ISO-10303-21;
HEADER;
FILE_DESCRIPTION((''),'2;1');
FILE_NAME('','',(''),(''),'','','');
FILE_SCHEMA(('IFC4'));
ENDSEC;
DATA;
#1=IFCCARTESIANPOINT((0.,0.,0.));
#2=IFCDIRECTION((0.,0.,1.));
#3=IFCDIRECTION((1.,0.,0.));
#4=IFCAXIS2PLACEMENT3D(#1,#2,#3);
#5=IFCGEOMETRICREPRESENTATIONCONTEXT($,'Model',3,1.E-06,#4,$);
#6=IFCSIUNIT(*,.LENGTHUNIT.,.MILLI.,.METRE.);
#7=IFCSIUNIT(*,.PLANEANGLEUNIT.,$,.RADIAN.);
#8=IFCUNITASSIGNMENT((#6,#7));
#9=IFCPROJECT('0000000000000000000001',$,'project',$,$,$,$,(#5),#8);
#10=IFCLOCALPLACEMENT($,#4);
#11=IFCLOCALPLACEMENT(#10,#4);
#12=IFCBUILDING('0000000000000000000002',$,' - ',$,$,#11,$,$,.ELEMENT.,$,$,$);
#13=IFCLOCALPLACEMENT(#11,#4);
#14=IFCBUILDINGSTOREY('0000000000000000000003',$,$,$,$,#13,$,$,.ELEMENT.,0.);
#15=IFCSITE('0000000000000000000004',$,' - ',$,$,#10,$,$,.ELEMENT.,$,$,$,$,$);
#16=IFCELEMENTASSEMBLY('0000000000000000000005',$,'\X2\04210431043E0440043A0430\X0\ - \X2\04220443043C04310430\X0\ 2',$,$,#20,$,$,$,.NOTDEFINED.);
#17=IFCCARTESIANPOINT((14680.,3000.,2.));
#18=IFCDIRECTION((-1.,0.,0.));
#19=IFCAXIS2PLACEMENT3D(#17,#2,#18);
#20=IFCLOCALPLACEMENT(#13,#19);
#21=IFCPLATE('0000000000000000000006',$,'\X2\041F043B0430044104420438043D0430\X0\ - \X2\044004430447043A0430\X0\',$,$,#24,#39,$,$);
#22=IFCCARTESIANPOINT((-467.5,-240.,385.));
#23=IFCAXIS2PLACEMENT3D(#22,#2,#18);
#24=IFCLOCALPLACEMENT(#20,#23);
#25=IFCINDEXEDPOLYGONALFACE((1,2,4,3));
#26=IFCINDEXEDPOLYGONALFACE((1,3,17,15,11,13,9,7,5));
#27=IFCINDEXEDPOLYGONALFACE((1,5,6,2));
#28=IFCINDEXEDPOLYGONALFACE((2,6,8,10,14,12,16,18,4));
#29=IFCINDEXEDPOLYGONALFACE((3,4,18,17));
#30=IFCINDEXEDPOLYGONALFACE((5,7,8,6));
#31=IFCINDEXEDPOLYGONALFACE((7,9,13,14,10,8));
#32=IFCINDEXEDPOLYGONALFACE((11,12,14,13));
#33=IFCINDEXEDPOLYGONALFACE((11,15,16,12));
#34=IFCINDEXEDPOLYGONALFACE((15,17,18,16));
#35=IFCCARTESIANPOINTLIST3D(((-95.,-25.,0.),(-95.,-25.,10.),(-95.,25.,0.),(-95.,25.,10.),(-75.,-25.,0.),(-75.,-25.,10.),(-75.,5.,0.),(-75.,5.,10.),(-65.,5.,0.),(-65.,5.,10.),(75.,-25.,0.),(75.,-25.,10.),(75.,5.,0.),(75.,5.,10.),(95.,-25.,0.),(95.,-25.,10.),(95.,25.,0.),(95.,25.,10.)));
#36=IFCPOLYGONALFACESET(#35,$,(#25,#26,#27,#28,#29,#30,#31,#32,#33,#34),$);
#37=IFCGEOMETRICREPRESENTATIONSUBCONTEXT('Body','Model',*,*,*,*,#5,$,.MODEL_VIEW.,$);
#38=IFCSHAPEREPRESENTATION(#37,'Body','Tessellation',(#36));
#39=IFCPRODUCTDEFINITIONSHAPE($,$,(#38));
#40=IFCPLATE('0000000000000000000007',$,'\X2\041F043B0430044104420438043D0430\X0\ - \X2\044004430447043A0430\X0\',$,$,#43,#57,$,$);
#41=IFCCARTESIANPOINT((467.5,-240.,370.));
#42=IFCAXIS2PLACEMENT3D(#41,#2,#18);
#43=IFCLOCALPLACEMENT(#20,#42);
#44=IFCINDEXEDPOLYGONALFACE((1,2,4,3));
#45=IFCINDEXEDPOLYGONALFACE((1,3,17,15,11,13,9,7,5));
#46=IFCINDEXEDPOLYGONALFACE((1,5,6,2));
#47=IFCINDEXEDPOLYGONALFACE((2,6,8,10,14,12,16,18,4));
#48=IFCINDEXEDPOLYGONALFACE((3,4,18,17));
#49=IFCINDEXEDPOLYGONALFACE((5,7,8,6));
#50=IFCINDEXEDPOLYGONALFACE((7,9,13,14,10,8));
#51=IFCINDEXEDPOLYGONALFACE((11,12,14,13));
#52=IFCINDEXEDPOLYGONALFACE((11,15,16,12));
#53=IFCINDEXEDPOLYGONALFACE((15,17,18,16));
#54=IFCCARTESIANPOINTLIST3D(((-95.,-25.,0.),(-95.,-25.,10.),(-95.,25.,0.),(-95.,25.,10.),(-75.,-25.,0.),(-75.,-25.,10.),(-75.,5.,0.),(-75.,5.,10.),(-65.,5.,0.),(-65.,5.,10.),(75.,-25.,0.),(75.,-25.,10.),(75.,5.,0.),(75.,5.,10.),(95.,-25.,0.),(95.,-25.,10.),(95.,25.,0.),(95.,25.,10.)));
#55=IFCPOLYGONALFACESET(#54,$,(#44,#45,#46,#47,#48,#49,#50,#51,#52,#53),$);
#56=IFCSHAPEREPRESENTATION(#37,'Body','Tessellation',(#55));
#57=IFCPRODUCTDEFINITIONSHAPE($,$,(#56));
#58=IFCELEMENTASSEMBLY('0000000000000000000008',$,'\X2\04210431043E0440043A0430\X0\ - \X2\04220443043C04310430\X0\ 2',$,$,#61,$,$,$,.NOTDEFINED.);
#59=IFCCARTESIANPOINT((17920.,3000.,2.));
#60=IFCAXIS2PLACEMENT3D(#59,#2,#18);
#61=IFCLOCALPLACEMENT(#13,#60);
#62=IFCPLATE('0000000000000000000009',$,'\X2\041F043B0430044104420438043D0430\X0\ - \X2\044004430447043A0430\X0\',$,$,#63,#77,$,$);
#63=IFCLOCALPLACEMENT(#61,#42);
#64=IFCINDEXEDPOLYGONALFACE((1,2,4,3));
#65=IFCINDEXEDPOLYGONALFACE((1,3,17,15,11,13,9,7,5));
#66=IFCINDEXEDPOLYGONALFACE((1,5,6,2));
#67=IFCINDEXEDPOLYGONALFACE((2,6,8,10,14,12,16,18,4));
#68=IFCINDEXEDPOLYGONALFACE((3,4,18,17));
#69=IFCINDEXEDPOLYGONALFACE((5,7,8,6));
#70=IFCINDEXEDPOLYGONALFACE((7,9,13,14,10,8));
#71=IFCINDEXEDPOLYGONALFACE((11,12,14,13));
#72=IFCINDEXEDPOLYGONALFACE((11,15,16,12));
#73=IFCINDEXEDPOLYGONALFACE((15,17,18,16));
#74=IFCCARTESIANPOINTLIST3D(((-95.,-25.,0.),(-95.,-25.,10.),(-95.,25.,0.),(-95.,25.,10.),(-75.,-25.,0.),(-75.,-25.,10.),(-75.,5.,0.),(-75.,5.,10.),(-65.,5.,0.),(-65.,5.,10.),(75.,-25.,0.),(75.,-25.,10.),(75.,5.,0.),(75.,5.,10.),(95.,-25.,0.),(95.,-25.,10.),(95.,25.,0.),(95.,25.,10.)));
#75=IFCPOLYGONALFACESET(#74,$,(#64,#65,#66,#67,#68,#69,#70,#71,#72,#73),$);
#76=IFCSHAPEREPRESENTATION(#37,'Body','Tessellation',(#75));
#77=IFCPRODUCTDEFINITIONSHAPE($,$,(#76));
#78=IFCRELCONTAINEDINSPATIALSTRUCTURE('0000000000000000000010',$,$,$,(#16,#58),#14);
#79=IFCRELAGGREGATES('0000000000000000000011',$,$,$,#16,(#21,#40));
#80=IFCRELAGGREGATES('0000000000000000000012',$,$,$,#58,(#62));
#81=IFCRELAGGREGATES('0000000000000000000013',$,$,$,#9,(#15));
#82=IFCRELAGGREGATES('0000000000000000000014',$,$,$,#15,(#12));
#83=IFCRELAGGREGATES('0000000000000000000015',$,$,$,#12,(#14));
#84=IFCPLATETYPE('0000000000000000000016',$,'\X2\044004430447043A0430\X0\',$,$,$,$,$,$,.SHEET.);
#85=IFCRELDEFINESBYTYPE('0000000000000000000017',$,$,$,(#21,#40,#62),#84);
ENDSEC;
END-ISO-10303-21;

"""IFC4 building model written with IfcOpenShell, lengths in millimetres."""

from ifc_helpers import new_model, si_unit, frame, origin_with_axes, place, context, subcontext, project, spatial, line, indexed_curve, outline, extrude, source, transform, mapped, type_object, element, aggregate, save


model = new_model("IFC4")

# Units and contexts
model_context = context("Model", 3, precision=1e-06, world=origin_with_axes())
body_context = subcontext(model_context, "Body", "Model", "MODEL_VIEW")
ifc_project = project(units=[si_unit("LENGTHUNIT", "METRE", prefix="MILLI"), si_unit("PLANEANGLEUNIT", "RADIAN")], contexts=[model_context])

# Site, building, storey
site_placement = place(None, origin_with_axes())
site = spatial("IfcSite", under=ifc_project, at=site_placement, Name=" - ", CompositionType="ELEMENT")
building_placement = place(site_placement, origin_with_axes())
building = spatial("IfcBuilding", under=site, at=building_placement, Name=" - ", CompositionType="ELEMENT")
storey_placement = place(building_placement, origin_with_axes())
storey = spatial("IfcBuildingStorey", under=building, at=storey_placement, CompositionType="ELEMENT", Elevation=0.0)

# Element assembly, plates
assembly_1_placement = place(storey_placement, frame((14680.0, 3000.0, 2.0), z_axis=(0.0, 0.0, 1.0), x_axis=(-1.0, 0.0, 0.0)))
assembly_1 = element("IfcElementAssembly", 1, at=assembly_1_placement, inside=storey, Name="Сборка - Тумба 2", PredefinedType="NOTDEFINED")
plate_type = type_object("IfcPlateType", Name="ручка", PredefinedType="SHEET")
shared_shape = source(origin_with_axes(), body_context, "Body", "SweptSolid", [
    extrude(outline(indexed_curve([(-95.0, -25.0), (-75.0, -25.0), (-75.0, 5.0), (-65.0, 5.0), (75.0, 5.0), (75.0, -25.0), (95.0, -25.0), (95.0, 25.0), (-95.0, 25.0)], segments=[line(1, 2), line(2, 3), line(3, 4), line(4, 5), line(5, 6), line(6, 7), line(7, 8), line(8, 9), line(9, 1)])), origin_with_axes(), (0.0, 0.0, 1.0), 10.0),
])
plate_1_placement = place(assembly_1_placement, frame((-467.5, -240.0, 385.0), z_axis=(0.0, 0.0, 1.0), x_axis=(-1.0, 0.0, 0.0)))
plate_1 = element("IfcPlate", 2, at=plate_1_placement, type_object=plate_type, Name="Пластина - ручка", context=body_context, shape_type="MappedRepresentation", body=[
    mapped(shared_shape, transform((0.0, 0.0, 0.0), x_axis=(1.0, 0.0, 0.0), y_axis=(0.0, 1.0, 0.0), z_axis=(0.0, 0.0, 1.0), scale=1.0)),
])
plate_2_placement = place(assembly_1_placement, frame((467.5, -240.0, 370.0), z_axis=(0.0, 0.0, 1.0), x_axis=(-1.0, 0.0, 0.0)))
plate_2 = element("IfcPlate", 3, at=plate_2_placement, type_object=plate_type, Name="Пластина - ручка", context=body_context, shape_type="MappedRepresentation", body=[
    mapped(shared_shape, transform((0.0, 0.0, 0.0), x_axis=(1.0, 0.0, 0.0), y_axis=(0.0, 1.0, 0.0), z_axis=(0.0, 0.0, 1.0), scale=1.0)),
])
aggregate(assembly_1, [plate_1, plate_2])

# Element assembly, plate
assembly_2_placement = place(storey_placement, frame((17920.0, 3000.0, 2.0), z_axis=(0.0, 0.0, 1.0), x_axis=(-1.0, 0.0, 0.0)))
assembly_2 = element("IfcElementAssembly", 4, at=assembly_2_placement, inside=storey, Name="Сборка - Тумба 2", PredefinedType="NOTDEFINED")
plate_3_placement = place(assembly_2_placement, frame((467.5, -240.0, 370.0), z_axis=(0.0, 0.0, 1.0), x_axis=(-1.0, 0.0, 0.0)))
plate_3 = element("IfcPlate", 5, at=plate_3_placement, type_object=plate_type, Name="Пластина - ручка", context=body_context, shape_type="MappedRepresentation", body=[
    mapped(shared_shape, transform((0.0, 0.0, 0.0), x_axis=(1.0, 0.0, 0.0), y_axis=(0.0, 1.0, 0.0), z_axis=(0.0, 0.0, 1.0), scale=1.0)),
])
aggregate(assembly_2, [plate_3])

save(model, "model.ifc")
